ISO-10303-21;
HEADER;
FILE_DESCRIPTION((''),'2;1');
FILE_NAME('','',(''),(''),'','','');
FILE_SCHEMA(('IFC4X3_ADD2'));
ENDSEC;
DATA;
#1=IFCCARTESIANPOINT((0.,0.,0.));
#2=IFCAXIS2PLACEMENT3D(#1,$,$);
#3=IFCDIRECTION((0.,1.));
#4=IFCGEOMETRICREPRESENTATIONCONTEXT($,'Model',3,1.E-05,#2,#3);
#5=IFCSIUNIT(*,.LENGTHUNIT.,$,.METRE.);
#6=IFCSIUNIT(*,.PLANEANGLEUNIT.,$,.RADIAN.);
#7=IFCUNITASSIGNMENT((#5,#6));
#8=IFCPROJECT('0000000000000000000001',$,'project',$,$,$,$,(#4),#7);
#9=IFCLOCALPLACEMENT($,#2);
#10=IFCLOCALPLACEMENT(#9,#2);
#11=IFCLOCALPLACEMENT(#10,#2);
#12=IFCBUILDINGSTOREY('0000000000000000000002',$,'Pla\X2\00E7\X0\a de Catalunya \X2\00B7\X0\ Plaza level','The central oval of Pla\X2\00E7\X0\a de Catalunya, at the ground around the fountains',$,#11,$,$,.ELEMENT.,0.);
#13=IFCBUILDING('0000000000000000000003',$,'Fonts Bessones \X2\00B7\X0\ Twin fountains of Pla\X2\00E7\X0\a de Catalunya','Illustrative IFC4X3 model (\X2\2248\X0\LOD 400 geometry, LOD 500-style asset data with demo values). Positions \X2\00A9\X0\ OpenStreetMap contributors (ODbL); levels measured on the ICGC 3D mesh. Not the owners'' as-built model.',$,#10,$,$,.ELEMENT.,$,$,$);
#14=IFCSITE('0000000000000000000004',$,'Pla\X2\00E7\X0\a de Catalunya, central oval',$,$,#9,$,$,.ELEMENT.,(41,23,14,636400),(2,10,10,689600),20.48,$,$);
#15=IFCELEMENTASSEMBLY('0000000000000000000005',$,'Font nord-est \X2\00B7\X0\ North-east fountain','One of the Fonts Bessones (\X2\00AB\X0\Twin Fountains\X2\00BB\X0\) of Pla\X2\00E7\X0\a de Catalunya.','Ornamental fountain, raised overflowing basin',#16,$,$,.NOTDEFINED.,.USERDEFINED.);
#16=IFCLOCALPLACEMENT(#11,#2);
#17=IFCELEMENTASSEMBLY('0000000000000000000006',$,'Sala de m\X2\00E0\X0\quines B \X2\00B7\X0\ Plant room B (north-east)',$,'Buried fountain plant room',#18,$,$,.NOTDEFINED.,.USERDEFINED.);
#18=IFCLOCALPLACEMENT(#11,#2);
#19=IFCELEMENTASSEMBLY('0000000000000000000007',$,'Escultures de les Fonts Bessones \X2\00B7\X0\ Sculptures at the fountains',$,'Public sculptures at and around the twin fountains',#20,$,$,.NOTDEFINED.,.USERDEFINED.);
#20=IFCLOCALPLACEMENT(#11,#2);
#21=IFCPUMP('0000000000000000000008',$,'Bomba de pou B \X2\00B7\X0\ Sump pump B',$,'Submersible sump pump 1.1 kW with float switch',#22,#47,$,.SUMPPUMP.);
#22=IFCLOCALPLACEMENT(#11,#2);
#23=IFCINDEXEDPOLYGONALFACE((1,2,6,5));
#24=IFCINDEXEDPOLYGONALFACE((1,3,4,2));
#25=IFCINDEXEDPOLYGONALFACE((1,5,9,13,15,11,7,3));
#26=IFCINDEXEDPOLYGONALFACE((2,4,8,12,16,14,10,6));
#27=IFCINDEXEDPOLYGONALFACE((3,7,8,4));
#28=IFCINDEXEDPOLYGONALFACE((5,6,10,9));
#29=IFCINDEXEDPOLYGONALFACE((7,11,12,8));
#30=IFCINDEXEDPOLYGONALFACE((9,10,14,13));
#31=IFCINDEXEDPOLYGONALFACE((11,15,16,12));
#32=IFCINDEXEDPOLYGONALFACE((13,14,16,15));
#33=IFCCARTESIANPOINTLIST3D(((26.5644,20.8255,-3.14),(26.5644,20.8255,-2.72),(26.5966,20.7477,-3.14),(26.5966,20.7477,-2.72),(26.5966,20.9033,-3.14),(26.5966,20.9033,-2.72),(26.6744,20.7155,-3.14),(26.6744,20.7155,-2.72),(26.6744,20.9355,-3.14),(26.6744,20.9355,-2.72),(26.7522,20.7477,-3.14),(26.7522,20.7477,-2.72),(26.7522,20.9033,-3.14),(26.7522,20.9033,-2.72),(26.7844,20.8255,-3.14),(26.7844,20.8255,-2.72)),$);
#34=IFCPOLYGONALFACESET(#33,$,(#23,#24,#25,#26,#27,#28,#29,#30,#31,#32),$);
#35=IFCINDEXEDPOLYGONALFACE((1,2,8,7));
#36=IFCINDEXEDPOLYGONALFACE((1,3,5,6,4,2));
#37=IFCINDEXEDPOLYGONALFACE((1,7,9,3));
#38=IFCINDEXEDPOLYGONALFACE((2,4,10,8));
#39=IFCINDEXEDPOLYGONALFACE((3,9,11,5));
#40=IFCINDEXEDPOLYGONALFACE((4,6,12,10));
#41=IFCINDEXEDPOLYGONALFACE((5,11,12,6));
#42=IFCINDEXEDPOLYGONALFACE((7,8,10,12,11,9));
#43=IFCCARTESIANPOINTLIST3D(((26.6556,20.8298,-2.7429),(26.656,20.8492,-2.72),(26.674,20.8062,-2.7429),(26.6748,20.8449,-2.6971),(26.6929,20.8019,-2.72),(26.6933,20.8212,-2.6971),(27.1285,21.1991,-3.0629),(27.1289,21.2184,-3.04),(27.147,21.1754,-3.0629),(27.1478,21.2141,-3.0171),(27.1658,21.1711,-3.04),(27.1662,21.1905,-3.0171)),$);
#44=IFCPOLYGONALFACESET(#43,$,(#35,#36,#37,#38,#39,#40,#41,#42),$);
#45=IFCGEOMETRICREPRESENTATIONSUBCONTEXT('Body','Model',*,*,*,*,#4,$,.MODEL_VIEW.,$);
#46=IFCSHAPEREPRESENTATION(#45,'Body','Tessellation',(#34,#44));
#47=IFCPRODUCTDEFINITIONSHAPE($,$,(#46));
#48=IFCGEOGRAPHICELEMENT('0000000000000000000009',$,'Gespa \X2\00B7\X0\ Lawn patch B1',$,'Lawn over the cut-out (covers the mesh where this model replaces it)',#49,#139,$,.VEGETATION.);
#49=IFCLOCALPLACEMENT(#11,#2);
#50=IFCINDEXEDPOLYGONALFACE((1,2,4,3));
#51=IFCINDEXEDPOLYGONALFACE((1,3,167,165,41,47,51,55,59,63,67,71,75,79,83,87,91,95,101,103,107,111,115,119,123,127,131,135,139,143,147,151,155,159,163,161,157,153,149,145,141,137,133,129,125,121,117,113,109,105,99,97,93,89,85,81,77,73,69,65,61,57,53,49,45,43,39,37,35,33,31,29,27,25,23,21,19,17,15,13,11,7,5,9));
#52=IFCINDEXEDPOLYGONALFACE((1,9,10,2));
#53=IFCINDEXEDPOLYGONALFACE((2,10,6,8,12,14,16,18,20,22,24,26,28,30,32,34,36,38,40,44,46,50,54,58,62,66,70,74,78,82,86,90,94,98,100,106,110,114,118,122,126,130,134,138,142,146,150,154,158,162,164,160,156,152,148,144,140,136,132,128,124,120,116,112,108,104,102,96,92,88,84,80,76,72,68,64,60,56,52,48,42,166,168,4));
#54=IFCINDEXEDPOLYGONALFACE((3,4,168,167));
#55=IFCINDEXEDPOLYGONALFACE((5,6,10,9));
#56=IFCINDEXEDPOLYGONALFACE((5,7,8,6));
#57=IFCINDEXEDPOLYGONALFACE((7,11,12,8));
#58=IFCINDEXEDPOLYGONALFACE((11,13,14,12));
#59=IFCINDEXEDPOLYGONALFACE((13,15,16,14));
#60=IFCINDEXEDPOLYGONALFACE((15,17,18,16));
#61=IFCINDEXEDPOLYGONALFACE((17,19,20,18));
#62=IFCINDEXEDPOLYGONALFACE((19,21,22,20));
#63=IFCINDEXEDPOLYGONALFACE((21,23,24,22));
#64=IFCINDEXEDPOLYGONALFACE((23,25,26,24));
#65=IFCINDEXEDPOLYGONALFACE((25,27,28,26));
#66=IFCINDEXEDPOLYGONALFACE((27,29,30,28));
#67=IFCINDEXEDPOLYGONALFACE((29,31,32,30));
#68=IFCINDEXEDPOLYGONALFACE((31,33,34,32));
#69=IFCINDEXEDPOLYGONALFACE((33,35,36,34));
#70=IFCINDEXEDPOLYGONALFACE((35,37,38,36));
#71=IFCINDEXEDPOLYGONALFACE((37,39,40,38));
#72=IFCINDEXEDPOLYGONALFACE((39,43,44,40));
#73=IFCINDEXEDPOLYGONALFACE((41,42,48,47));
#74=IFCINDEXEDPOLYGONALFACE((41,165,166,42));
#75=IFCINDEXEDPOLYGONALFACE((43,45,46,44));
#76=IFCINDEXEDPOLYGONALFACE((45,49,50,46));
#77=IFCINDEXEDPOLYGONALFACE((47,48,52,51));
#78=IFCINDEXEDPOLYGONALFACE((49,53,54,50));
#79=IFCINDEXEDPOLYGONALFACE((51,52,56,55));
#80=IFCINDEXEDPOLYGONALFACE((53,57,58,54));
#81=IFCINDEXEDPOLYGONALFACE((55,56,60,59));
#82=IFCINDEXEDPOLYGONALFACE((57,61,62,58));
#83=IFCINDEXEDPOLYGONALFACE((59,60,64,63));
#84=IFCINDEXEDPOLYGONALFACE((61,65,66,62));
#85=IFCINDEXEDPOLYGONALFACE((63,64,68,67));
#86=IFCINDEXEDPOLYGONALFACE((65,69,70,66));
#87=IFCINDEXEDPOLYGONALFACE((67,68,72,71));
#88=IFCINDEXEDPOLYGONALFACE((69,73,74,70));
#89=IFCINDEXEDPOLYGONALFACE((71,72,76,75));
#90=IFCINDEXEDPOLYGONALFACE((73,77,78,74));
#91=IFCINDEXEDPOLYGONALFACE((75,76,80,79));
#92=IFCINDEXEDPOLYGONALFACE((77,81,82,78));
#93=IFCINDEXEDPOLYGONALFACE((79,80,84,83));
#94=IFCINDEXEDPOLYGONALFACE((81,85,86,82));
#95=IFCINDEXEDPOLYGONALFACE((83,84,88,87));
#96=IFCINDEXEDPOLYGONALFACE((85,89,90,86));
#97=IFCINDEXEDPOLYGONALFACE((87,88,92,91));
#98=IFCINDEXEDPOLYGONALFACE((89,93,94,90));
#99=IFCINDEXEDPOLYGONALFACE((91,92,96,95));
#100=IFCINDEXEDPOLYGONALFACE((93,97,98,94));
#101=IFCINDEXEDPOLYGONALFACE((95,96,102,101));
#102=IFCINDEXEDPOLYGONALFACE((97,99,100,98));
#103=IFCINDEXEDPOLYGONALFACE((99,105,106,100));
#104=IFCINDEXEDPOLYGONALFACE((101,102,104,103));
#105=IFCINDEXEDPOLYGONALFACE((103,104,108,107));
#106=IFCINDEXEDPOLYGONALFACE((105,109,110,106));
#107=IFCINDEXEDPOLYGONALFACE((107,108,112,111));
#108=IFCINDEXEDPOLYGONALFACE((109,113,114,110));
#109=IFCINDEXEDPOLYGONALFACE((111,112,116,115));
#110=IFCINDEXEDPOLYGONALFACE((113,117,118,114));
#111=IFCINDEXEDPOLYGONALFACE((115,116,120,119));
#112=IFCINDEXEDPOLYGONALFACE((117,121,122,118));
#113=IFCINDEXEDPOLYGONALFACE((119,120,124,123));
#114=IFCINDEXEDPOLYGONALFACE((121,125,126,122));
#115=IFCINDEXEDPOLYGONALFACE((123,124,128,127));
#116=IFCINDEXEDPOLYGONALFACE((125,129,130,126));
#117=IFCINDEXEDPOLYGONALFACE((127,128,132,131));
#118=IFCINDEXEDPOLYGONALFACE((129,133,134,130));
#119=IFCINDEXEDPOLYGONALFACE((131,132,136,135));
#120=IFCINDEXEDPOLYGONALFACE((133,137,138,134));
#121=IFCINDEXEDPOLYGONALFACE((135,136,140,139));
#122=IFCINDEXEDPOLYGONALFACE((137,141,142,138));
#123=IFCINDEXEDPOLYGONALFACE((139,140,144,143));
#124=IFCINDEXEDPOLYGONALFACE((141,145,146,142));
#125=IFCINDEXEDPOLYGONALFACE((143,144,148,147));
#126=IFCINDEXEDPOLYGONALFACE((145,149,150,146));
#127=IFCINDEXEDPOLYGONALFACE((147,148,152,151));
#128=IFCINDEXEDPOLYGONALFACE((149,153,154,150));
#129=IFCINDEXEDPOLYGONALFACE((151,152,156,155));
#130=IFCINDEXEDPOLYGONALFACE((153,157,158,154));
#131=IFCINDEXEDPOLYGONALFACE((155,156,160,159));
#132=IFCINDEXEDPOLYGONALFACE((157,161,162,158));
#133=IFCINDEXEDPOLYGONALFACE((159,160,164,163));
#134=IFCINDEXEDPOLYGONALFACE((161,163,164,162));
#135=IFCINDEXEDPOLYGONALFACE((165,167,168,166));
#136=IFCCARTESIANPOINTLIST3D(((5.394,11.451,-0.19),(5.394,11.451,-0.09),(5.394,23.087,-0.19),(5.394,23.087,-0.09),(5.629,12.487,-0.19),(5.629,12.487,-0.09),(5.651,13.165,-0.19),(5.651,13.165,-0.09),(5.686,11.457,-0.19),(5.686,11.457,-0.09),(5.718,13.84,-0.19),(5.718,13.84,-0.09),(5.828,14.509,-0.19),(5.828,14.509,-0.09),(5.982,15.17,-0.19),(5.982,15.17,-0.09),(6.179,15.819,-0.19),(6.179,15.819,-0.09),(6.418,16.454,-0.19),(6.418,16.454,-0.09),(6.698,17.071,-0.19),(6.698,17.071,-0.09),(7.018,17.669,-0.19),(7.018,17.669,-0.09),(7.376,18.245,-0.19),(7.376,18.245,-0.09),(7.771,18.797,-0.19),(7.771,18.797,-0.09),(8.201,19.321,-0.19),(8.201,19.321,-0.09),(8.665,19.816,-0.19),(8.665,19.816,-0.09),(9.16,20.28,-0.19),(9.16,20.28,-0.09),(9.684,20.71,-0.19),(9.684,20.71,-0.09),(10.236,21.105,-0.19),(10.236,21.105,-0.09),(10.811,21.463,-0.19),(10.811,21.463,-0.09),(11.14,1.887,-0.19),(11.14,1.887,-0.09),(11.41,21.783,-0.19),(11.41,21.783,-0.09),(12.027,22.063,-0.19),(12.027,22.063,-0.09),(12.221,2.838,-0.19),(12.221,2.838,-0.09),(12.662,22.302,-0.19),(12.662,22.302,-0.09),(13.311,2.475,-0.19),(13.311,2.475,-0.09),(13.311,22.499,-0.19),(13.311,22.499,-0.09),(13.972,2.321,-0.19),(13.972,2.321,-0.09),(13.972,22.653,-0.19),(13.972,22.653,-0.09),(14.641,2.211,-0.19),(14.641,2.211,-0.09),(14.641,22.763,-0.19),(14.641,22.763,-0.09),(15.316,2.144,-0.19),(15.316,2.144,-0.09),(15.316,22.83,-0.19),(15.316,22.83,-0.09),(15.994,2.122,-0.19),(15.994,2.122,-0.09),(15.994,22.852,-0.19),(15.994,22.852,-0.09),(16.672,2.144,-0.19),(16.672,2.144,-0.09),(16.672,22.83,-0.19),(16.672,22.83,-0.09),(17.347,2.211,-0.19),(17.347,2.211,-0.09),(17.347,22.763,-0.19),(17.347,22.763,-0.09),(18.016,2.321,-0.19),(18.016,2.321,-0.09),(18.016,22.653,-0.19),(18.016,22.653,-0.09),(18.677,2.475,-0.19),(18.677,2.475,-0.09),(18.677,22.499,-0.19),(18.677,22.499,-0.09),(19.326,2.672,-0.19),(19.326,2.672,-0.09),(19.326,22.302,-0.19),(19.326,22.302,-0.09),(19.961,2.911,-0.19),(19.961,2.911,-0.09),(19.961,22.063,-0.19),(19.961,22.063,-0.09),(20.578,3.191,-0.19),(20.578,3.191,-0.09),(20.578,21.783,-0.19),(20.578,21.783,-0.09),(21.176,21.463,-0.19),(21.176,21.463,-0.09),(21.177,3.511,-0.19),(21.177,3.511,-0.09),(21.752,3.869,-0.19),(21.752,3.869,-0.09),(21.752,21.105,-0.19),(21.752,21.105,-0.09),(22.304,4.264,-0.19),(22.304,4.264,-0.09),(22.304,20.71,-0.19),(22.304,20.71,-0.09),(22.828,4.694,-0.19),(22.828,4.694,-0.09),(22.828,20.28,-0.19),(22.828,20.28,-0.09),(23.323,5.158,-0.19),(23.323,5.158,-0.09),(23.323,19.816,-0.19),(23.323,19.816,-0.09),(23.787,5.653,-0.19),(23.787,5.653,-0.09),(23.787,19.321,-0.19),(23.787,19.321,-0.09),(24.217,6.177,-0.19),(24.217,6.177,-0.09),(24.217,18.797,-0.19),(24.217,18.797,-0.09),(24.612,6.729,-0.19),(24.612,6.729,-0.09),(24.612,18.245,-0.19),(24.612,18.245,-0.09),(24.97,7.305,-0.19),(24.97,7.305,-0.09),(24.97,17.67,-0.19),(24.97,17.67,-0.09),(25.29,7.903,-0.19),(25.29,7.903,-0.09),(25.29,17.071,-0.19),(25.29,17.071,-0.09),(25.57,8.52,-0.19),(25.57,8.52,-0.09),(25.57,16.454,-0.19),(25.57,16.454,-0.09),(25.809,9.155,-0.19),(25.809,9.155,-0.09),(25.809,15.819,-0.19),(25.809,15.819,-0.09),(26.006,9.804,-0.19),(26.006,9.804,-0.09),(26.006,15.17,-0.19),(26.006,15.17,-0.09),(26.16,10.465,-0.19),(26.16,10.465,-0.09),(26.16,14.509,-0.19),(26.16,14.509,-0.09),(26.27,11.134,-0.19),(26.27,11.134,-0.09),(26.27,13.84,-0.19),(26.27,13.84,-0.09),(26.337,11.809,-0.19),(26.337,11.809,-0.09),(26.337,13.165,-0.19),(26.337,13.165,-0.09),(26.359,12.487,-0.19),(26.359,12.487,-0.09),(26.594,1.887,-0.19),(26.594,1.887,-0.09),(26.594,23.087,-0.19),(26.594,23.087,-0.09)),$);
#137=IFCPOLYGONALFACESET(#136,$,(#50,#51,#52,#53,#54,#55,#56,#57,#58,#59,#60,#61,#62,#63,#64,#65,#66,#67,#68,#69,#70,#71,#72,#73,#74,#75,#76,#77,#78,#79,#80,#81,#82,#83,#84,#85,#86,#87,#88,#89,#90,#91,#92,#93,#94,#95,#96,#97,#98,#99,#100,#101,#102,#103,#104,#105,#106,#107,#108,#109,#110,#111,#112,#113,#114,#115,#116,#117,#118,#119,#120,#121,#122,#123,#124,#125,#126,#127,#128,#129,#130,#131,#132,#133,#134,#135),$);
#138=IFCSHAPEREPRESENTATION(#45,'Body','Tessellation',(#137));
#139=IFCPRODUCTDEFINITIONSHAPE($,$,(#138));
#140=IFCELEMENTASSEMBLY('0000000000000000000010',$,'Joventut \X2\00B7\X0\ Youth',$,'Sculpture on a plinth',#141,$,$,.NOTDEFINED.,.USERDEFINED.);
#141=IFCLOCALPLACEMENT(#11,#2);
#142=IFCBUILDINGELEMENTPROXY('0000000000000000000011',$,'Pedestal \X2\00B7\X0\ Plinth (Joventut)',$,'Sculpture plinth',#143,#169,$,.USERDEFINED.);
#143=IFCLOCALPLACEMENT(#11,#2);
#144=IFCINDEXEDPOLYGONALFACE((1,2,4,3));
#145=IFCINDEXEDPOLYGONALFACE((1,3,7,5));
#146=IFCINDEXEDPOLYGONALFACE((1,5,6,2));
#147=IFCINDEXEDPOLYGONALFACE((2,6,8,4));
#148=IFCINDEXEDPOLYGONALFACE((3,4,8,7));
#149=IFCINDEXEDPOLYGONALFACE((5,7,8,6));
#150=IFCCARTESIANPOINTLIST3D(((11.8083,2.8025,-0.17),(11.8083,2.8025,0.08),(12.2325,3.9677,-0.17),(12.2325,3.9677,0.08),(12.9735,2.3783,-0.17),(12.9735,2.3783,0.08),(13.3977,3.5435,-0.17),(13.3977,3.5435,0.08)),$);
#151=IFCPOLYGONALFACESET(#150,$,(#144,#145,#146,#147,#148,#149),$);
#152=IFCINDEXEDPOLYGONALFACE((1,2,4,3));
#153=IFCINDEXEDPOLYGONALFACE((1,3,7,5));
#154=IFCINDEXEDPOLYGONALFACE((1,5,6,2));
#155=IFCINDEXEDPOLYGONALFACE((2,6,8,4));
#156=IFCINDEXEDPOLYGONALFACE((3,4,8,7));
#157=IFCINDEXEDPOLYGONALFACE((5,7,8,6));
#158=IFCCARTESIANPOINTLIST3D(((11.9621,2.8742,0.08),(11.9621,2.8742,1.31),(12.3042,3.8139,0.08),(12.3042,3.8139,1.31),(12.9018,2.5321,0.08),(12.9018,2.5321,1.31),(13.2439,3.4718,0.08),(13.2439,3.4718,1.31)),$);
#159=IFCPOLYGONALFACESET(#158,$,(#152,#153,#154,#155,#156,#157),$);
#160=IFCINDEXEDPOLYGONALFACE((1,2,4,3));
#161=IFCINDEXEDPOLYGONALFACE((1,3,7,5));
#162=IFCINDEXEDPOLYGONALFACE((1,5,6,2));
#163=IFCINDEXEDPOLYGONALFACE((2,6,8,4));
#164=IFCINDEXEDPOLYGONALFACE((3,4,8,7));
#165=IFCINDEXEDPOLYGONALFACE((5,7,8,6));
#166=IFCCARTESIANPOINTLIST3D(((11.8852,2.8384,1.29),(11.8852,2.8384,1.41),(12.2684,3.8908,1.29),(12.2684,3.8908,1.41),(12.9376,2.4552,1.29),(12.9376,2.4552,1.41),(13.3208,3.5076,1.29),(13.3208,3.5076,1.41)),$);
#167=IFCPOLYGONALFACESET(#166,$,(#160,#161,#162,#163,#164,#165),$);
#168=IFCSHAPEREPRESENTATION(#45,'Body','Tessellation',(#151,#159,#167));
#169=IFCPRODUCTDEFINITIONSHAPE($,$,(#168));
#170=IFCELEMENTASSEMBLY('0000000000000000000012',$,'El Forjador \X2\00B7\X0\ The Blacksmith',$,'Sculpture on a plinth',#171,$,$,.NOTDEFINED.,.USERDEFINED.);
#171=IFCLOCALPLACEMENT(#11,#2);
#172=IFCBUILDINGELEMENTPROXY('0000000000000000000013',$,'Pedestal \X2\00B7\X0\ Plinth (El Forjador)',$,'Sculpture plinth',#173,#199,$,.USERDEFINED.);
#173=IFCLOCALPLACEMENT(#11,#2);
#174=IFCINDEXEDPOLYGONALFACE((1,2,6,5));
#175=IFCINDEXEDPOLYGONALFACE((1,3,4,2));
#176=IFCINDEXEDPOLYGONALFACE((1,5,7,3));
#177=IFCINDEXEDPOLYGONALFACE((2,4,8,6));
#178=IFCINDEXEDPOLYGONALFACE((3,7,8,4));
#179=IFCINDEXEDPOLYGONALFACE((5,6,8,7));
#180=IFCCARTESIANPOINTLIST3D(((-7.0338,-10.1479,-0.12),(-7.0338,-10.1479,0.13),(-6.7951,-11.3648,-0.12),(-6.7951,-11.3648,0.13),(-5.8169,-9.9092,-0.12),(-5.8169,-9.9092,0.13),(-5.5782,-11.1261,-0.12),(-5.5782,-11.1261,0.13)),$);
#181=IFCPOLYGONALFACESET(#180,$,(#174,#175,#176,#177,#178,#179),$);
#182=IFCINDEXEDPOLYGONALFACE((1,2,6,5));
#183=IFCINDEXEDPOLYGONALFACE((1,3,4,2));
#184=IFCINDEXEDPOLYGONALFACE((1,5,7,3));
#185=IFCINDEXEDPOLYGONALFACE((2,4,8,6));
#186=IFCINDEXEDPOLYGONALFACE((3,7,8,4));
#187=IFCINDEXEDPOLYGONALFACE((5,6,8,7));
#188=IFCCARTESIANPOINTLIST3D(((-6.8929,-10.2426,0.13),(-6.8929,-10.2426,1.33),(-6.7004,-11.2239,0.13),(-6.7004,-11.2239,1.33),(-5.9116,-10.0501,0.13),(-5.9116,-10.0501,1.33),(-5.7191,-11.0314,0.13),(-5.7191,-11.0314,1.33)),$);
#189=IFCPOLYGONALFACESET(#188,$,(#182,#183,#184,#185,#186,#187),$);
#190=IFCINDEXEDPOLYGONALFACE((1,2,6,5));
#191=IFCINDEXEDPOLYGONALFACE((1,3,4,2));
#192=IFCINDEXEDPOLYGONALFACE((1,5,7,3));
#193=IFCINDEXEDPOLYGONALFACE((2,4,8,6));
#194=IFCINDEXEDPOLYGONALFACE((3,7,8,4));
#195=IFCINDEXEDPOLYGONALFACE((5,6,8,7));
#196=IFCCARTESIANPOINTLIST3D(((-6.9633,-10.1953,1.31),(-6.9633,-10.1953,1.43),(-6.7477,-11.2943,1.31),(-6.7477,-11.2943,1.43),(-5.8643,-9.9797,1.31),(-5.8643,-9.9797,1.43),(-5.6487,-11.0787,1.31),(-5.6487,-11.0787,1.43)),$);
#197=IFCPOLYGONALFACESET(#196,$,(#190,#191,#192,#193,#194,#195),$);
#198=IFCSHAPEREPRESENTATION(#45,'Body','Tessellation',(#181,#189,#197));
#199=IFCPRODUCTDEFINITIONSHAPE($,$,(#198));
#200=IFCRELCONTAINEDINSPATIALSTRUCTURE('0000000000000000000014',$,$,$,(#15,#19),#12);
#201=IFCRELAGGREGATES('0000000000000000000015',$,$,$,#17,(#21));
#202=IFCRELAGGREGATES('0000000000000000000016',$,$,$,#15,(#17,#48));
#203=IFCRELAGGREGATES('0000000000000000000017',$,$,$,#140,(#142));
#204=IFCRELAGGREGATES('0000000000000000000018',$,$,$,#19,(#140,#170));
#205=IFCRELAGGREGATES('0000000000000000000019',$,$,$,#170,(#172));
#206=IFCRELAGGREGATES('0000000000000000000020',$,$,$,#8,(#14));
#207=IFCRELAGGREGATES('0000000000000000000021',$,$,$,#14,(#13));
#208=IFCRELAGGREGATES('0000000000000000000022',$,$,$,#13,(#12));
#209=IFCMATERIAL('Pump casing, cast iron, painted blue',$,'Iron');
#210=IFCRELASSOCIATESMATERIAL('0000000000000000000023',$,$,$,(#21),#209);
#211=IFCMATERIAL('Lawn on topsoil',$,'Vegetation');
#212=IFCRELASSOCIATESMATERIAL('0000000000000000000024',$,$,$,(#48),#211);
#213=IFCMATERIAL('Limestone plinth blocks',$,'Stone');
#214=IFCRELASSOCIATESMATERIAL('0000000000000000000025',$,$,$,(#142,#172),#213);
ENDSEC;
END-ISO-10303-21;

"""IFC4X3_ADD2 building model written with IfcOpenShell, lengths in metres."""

from ifc_helpers import new_model, si_unit, direction, frame, frame_2d, origin, place, context, subcontext, project, spatial, polyline, rectangle, outline, extrude, material, element, aggregate, save


model = new_model("IFC4X3_ADD2")

# Units and contexts
model_context = context("Model", 3, precision=1e-05, world=origin(), true_north=direction((0.0, 1.0)))
body_context = subcontext(model_context, "Body", "Model", "MODEL_VIEW")
ifc_project = project(units=[si_unit("LENGTHUNIT", "METRE"), si_unit("PLANEANGLEUNIT", "RADIAN")], contexts=[model_context])

# Site, building, storey
site_placement = place(None, origin())
site = spatial("IfcSite", under=ifc_project, at=site_placement, Name="Plaça de Catalunya, central oval", CompositionType="ELEMENT", RefLatitude=(41, 23, 14, 636400), RefLongitude=(2, 10, 10, 689600), RefElevation=20.48)
building_placement = place(site_placement, origin())
building = spatial("IfcBuilding", under=site, at=building_placement, Name="Fonts Bessones · Twin fountains of Plaça de Catalunya", Description="Illustrative IFC4X3 model (≈LOD 400 geometry, LOD 500-style asset data with demo values). Positions © OpenStreetMap contributors (ODbL); levels measured on the ICGC 3D mesh. Not the owners' as-built model.", CompositionType="ELEMENT")
storey_placement = place(building_placement, origin())
storey = spatial("IfcBuildingStorey", under=building, at=storey_placement, Name="Plaça de Catalunya · Plaza level", Description="The central oval of Plaça de Catalunya, at the ground around the fountains", CompositionType="ELEMENT", Elevation=0.0)

# Element assemblies
assembly_1_placement = place(building_placement, origin())
assembly_1 = element("IfcElementAssembly", 1, at=assembly_1_placement, inside=storey, Name="Font nord-est · North-east fountain", Description="One of the Fonts Bessones («Twin Fountains») of Plaça de Catalunya.", ObjectType="Ornamental fountain, raised overflowing basin", AssemblyPlace="NOTDEFINED", PredefinedType="USERDEFINED")
assembly_2_placement = place(building_placement, origin())
assembly_2 = element("IfcElementAssembly", 2, at=assembly_2_placement, Name="Sala de màquines B · Plant room B (north-east)", ObjectType="Buried fountain plant room", AssemblyPlace="NOTDEFINED", PredefinedType="USERDEFINED")

# Element assembly
assembly_3_placement = place(building_placement, origin())
assembly_3 = element("IfcElementAssembly", 3, at=assembly_3_placement, inside=storey, Name="Escultures de les Fonts Bessones · Sculptures at the fountains", ObjectType="Public sculptures at and around the twin fountains", AssemblyPlace="NOTDEFINED", PredefinedType="USERDEFINED")

# Shared definitions
ifc_material_1 = material(Name="Pump casing, cast iron, painted blue", Category="Iron")

# Pump
pump_1_placement = place(building_placement, origin())
pump_1 = element("IfcPump", 4, at=pump_1_placement, material=ifc_material_1, Name="Bomba de pou B · Sump pump B", ObjectType="Submersible sump pump 1.1 kW with float switch", PredefinedType="SUMPPUMP", context=body_context, shape_type="SweptSolid", body=[
    extrude(outline(polyline([(26.7844, 20.8255), (26.7522, 20.9033), (26.6744, 20.9355), (26.5966, 20.9033), (26.5644, 20.8255), (26.5966, 20.7477), (26.6744, 20.7155), (26.7522, 20.7477), (26.7844, 20.8255)])), frame((0.0, 0.0, -3.14)), (0.0, 0.0, 1.0), 0.42),
    extrude(outline(polyline([(0.03, 0.0), (0.015, 0.026), (-0.015, 0.026), (-0.03, 0.0), (-0.015, -0.026), (0.015, -0.026), (0.03, 0.0)])), frame((26.6744, 20.8255, -2.72), z_axis=(0.695491, 0.542991, -0.470588), x_axis=(0.61539, -0.788223, 0.0)), (0.0, 0.0, 1.0), 0.68),
])
aggregate(assembly_2, [pump_1])

# Geographic element
ifc_material_2 = material(Name="Lawn on topsoil", Category="Vegetation")
geographic_element_placement = place(building_placement, origin())
geographic_element = element("IfcGeographicElement", 5, at=geographic_element_placement, material=ifc_material_2, Name="Gespa · Lawn patch B1", ObjectType="Lawn over the cut-out (covers the mesh where this model replaces it)", PredefinedType="VEGETATION", context=body_context, shape_type="SweptSolid", body=[
    extrude(outline(polyline([(5.394, 23.087), (26.594, 23.087), (26.594, 1.887), (11.14, 1.887), (12.221, 2.838), (13.311, 2.475), (13.972, 2.321), (14.641, 2.211), (15.316, 2.144), (15.994, 2.122), (16.672, 2.144), (17.347, 2.211), (18.016, 2.321), (18.677, 2.475), (19.326, 2.672), (19.961, 2.911), (20.578, 3.191), (21.177, 3.511), (21.752, 3.869), (22.304, 4.264), (22.828, 4.694), (23.323, 5.158), (23.787, 5.653), (24.217, 6.177), (24.612, 6.729), (24.97, 7.305), (25.29, 7.903), (25.57, 8.52), (25.809, 9.155), (26.006, 9.804), (26.16, 10.465), (26.27, 11.134), (26.337, 11.809), (26.359, 12.487), (26.337, 13.165), (26.27, 13.84), (26.16, 14.509), (26.006, 15.17), (25.809, 15.819), (25.57, 16.454), (25.29, 17.071), (24.97, 17.67), (24.612, 18.245), (24.217, 18.797), (23.787, 19.321), (23.323, 19.816), (22.828, 20.28), (22.304, 20.71), (21.752, 21.105), (21.176, 21.463), (20.578, 21.783), (19.961, 22.063), (19.326, 22.302), (18.677, 22.499), (18.016, 22.653), (17.347, 22.763), (16.672, 22.83), (15.994, 22.852), (15.316, 22.83), (14.641, 22.763), (13.972, 22.653), (13.311, 22.499), (12.662, 22.302), (12.027, 22.063), (11.41, 21.783), (10.811, 21.463), (10.236, 21.105), (9.684, 20.71), (9.16, 20.28), (8.665, 19.816), (8.201, 19.321), (7.771, 18.797), (7.376, 18.245), (7.018, 17.669), (6.698, 17.071), (6.418, 16.454), (6.179, 15.819), (5.982, 15.17), (5.828, 14.509), (5.718, 13.84), (5.651, 13.165), (5.629, 12.487), (5.686, 11.457), (5.394, 11.451), (5.394, 23.087)]), holes=[]), frame((0.0, 0.0, -0.19)), (0.0, 0.0, 1.0), 0.1),
])
aggregate(assembly_1, [assembly_2, geographic_element])

# Element assembly, building element proxy
assembly_4_placement = place(building_placement, origin())
assembly_4 = element("IfcElementAssembly", 6, at=assembly_4_placement, Name="Joventut · Youth", ObjectType="Sculpture on a plinth", AssemblyPlace="NOTDEFINED", PredefinedType="USERDEFINED")
ifc_material_3 = material(Name="Limestone plinth blocks", Category="Stone")
proxy_1_placement = place(building_placement, origin())
proxy_1 = element("IfcBuildingElementProxy", 7, at=proxy_1_placement, material=ifc_material_3, Name="Pedestal · Plinth (Joventut)", ObjectType="Sculpture plinth", PredefinedType="USERDEFINED", context=body_context, shape_type="SweptSolid", body=[
    extrude(rectangle(XDim=1.24, YDim=1.24, at=frame_2d((0.0, 0.0), x_axis=(-0.342108, -0.939661))), frame((12.603, 3.173, -0.17)), (0.0, 0.0, 1.0), 0.25),
    extrude(rectangle(XDim=1.0, YDim=1.0, at=frame_2d((0.0, 0.0), x_axis=(-0.342108, -0.939661))), frame((12.603, 3.173, 0.08)), (0.0, 0.0, 1.0), 1.23),
    extrude(rectangle(XDim=1.12, YDim=1.12, at=frame_2d((0.0, 0.0), x_axis=(-0.342108, -0.939661))), frame((12.603, 3.173, 1.29)), (0.0, 0.0, 1.0), 0.12),
])
aggregate(assembly_4, [proxy_1])

# Element assembly
assembly_5_placement = place(building_placement, origin())
assembly_5 = element("IfcElementAssembly", 8, at=assembly_5_placement, Name="El Forjador · The Blacksmith", ObjectType="Sculpture on a plinth", AssemblyPlace="NOTDEFINED", PredefinedType="USERDEFINED")
aggregate(assembly_3, [assembly_4, assembly_5])

# Building element proxy
proxy_2_placement = place(building_placement, origin())
proxy_2 = element("IfcBuildingElementProxy", 9, at=proxy_2_placement, material=ifc_material_3, Name="Pedestal · Plinth (El Forjador)", ObjectType="Sculpture plinth", PredefinedType="USERDEFINED", context=body_context, shape_type="SweptSolid", body=[
    extrude(rectangle(XDim=1.24, YDim=1.24, at=frame_2d((0.0, 0.0), x_axis=(0.981298, 0.192494))), frame((-6.306, -10.637, -0.12)), (0.0, 0.0, 1.0), 0.25),
    extrude(rectangle(XDim=1.0, YDim=1.0, at=frame_2d((0.0, 0.0), x_axis=(0.981298, 0.192494))), frame((-6.306, -10.637, 0.13)), (0.0, 0.0, 1.0), 1.2),
    extrude(rectangle(XDim=1.12, YDim=1.12, at=frame_2d((0.0, 0.0), x_axis=(0.981298, 0.192494))), frame((-6.306, -10.637, 1.31)), (0.0, 0.0, 1.0), 0.12),
])
aggregate(assembly_5, [proxy_2])

save(model, "model.ifc")
